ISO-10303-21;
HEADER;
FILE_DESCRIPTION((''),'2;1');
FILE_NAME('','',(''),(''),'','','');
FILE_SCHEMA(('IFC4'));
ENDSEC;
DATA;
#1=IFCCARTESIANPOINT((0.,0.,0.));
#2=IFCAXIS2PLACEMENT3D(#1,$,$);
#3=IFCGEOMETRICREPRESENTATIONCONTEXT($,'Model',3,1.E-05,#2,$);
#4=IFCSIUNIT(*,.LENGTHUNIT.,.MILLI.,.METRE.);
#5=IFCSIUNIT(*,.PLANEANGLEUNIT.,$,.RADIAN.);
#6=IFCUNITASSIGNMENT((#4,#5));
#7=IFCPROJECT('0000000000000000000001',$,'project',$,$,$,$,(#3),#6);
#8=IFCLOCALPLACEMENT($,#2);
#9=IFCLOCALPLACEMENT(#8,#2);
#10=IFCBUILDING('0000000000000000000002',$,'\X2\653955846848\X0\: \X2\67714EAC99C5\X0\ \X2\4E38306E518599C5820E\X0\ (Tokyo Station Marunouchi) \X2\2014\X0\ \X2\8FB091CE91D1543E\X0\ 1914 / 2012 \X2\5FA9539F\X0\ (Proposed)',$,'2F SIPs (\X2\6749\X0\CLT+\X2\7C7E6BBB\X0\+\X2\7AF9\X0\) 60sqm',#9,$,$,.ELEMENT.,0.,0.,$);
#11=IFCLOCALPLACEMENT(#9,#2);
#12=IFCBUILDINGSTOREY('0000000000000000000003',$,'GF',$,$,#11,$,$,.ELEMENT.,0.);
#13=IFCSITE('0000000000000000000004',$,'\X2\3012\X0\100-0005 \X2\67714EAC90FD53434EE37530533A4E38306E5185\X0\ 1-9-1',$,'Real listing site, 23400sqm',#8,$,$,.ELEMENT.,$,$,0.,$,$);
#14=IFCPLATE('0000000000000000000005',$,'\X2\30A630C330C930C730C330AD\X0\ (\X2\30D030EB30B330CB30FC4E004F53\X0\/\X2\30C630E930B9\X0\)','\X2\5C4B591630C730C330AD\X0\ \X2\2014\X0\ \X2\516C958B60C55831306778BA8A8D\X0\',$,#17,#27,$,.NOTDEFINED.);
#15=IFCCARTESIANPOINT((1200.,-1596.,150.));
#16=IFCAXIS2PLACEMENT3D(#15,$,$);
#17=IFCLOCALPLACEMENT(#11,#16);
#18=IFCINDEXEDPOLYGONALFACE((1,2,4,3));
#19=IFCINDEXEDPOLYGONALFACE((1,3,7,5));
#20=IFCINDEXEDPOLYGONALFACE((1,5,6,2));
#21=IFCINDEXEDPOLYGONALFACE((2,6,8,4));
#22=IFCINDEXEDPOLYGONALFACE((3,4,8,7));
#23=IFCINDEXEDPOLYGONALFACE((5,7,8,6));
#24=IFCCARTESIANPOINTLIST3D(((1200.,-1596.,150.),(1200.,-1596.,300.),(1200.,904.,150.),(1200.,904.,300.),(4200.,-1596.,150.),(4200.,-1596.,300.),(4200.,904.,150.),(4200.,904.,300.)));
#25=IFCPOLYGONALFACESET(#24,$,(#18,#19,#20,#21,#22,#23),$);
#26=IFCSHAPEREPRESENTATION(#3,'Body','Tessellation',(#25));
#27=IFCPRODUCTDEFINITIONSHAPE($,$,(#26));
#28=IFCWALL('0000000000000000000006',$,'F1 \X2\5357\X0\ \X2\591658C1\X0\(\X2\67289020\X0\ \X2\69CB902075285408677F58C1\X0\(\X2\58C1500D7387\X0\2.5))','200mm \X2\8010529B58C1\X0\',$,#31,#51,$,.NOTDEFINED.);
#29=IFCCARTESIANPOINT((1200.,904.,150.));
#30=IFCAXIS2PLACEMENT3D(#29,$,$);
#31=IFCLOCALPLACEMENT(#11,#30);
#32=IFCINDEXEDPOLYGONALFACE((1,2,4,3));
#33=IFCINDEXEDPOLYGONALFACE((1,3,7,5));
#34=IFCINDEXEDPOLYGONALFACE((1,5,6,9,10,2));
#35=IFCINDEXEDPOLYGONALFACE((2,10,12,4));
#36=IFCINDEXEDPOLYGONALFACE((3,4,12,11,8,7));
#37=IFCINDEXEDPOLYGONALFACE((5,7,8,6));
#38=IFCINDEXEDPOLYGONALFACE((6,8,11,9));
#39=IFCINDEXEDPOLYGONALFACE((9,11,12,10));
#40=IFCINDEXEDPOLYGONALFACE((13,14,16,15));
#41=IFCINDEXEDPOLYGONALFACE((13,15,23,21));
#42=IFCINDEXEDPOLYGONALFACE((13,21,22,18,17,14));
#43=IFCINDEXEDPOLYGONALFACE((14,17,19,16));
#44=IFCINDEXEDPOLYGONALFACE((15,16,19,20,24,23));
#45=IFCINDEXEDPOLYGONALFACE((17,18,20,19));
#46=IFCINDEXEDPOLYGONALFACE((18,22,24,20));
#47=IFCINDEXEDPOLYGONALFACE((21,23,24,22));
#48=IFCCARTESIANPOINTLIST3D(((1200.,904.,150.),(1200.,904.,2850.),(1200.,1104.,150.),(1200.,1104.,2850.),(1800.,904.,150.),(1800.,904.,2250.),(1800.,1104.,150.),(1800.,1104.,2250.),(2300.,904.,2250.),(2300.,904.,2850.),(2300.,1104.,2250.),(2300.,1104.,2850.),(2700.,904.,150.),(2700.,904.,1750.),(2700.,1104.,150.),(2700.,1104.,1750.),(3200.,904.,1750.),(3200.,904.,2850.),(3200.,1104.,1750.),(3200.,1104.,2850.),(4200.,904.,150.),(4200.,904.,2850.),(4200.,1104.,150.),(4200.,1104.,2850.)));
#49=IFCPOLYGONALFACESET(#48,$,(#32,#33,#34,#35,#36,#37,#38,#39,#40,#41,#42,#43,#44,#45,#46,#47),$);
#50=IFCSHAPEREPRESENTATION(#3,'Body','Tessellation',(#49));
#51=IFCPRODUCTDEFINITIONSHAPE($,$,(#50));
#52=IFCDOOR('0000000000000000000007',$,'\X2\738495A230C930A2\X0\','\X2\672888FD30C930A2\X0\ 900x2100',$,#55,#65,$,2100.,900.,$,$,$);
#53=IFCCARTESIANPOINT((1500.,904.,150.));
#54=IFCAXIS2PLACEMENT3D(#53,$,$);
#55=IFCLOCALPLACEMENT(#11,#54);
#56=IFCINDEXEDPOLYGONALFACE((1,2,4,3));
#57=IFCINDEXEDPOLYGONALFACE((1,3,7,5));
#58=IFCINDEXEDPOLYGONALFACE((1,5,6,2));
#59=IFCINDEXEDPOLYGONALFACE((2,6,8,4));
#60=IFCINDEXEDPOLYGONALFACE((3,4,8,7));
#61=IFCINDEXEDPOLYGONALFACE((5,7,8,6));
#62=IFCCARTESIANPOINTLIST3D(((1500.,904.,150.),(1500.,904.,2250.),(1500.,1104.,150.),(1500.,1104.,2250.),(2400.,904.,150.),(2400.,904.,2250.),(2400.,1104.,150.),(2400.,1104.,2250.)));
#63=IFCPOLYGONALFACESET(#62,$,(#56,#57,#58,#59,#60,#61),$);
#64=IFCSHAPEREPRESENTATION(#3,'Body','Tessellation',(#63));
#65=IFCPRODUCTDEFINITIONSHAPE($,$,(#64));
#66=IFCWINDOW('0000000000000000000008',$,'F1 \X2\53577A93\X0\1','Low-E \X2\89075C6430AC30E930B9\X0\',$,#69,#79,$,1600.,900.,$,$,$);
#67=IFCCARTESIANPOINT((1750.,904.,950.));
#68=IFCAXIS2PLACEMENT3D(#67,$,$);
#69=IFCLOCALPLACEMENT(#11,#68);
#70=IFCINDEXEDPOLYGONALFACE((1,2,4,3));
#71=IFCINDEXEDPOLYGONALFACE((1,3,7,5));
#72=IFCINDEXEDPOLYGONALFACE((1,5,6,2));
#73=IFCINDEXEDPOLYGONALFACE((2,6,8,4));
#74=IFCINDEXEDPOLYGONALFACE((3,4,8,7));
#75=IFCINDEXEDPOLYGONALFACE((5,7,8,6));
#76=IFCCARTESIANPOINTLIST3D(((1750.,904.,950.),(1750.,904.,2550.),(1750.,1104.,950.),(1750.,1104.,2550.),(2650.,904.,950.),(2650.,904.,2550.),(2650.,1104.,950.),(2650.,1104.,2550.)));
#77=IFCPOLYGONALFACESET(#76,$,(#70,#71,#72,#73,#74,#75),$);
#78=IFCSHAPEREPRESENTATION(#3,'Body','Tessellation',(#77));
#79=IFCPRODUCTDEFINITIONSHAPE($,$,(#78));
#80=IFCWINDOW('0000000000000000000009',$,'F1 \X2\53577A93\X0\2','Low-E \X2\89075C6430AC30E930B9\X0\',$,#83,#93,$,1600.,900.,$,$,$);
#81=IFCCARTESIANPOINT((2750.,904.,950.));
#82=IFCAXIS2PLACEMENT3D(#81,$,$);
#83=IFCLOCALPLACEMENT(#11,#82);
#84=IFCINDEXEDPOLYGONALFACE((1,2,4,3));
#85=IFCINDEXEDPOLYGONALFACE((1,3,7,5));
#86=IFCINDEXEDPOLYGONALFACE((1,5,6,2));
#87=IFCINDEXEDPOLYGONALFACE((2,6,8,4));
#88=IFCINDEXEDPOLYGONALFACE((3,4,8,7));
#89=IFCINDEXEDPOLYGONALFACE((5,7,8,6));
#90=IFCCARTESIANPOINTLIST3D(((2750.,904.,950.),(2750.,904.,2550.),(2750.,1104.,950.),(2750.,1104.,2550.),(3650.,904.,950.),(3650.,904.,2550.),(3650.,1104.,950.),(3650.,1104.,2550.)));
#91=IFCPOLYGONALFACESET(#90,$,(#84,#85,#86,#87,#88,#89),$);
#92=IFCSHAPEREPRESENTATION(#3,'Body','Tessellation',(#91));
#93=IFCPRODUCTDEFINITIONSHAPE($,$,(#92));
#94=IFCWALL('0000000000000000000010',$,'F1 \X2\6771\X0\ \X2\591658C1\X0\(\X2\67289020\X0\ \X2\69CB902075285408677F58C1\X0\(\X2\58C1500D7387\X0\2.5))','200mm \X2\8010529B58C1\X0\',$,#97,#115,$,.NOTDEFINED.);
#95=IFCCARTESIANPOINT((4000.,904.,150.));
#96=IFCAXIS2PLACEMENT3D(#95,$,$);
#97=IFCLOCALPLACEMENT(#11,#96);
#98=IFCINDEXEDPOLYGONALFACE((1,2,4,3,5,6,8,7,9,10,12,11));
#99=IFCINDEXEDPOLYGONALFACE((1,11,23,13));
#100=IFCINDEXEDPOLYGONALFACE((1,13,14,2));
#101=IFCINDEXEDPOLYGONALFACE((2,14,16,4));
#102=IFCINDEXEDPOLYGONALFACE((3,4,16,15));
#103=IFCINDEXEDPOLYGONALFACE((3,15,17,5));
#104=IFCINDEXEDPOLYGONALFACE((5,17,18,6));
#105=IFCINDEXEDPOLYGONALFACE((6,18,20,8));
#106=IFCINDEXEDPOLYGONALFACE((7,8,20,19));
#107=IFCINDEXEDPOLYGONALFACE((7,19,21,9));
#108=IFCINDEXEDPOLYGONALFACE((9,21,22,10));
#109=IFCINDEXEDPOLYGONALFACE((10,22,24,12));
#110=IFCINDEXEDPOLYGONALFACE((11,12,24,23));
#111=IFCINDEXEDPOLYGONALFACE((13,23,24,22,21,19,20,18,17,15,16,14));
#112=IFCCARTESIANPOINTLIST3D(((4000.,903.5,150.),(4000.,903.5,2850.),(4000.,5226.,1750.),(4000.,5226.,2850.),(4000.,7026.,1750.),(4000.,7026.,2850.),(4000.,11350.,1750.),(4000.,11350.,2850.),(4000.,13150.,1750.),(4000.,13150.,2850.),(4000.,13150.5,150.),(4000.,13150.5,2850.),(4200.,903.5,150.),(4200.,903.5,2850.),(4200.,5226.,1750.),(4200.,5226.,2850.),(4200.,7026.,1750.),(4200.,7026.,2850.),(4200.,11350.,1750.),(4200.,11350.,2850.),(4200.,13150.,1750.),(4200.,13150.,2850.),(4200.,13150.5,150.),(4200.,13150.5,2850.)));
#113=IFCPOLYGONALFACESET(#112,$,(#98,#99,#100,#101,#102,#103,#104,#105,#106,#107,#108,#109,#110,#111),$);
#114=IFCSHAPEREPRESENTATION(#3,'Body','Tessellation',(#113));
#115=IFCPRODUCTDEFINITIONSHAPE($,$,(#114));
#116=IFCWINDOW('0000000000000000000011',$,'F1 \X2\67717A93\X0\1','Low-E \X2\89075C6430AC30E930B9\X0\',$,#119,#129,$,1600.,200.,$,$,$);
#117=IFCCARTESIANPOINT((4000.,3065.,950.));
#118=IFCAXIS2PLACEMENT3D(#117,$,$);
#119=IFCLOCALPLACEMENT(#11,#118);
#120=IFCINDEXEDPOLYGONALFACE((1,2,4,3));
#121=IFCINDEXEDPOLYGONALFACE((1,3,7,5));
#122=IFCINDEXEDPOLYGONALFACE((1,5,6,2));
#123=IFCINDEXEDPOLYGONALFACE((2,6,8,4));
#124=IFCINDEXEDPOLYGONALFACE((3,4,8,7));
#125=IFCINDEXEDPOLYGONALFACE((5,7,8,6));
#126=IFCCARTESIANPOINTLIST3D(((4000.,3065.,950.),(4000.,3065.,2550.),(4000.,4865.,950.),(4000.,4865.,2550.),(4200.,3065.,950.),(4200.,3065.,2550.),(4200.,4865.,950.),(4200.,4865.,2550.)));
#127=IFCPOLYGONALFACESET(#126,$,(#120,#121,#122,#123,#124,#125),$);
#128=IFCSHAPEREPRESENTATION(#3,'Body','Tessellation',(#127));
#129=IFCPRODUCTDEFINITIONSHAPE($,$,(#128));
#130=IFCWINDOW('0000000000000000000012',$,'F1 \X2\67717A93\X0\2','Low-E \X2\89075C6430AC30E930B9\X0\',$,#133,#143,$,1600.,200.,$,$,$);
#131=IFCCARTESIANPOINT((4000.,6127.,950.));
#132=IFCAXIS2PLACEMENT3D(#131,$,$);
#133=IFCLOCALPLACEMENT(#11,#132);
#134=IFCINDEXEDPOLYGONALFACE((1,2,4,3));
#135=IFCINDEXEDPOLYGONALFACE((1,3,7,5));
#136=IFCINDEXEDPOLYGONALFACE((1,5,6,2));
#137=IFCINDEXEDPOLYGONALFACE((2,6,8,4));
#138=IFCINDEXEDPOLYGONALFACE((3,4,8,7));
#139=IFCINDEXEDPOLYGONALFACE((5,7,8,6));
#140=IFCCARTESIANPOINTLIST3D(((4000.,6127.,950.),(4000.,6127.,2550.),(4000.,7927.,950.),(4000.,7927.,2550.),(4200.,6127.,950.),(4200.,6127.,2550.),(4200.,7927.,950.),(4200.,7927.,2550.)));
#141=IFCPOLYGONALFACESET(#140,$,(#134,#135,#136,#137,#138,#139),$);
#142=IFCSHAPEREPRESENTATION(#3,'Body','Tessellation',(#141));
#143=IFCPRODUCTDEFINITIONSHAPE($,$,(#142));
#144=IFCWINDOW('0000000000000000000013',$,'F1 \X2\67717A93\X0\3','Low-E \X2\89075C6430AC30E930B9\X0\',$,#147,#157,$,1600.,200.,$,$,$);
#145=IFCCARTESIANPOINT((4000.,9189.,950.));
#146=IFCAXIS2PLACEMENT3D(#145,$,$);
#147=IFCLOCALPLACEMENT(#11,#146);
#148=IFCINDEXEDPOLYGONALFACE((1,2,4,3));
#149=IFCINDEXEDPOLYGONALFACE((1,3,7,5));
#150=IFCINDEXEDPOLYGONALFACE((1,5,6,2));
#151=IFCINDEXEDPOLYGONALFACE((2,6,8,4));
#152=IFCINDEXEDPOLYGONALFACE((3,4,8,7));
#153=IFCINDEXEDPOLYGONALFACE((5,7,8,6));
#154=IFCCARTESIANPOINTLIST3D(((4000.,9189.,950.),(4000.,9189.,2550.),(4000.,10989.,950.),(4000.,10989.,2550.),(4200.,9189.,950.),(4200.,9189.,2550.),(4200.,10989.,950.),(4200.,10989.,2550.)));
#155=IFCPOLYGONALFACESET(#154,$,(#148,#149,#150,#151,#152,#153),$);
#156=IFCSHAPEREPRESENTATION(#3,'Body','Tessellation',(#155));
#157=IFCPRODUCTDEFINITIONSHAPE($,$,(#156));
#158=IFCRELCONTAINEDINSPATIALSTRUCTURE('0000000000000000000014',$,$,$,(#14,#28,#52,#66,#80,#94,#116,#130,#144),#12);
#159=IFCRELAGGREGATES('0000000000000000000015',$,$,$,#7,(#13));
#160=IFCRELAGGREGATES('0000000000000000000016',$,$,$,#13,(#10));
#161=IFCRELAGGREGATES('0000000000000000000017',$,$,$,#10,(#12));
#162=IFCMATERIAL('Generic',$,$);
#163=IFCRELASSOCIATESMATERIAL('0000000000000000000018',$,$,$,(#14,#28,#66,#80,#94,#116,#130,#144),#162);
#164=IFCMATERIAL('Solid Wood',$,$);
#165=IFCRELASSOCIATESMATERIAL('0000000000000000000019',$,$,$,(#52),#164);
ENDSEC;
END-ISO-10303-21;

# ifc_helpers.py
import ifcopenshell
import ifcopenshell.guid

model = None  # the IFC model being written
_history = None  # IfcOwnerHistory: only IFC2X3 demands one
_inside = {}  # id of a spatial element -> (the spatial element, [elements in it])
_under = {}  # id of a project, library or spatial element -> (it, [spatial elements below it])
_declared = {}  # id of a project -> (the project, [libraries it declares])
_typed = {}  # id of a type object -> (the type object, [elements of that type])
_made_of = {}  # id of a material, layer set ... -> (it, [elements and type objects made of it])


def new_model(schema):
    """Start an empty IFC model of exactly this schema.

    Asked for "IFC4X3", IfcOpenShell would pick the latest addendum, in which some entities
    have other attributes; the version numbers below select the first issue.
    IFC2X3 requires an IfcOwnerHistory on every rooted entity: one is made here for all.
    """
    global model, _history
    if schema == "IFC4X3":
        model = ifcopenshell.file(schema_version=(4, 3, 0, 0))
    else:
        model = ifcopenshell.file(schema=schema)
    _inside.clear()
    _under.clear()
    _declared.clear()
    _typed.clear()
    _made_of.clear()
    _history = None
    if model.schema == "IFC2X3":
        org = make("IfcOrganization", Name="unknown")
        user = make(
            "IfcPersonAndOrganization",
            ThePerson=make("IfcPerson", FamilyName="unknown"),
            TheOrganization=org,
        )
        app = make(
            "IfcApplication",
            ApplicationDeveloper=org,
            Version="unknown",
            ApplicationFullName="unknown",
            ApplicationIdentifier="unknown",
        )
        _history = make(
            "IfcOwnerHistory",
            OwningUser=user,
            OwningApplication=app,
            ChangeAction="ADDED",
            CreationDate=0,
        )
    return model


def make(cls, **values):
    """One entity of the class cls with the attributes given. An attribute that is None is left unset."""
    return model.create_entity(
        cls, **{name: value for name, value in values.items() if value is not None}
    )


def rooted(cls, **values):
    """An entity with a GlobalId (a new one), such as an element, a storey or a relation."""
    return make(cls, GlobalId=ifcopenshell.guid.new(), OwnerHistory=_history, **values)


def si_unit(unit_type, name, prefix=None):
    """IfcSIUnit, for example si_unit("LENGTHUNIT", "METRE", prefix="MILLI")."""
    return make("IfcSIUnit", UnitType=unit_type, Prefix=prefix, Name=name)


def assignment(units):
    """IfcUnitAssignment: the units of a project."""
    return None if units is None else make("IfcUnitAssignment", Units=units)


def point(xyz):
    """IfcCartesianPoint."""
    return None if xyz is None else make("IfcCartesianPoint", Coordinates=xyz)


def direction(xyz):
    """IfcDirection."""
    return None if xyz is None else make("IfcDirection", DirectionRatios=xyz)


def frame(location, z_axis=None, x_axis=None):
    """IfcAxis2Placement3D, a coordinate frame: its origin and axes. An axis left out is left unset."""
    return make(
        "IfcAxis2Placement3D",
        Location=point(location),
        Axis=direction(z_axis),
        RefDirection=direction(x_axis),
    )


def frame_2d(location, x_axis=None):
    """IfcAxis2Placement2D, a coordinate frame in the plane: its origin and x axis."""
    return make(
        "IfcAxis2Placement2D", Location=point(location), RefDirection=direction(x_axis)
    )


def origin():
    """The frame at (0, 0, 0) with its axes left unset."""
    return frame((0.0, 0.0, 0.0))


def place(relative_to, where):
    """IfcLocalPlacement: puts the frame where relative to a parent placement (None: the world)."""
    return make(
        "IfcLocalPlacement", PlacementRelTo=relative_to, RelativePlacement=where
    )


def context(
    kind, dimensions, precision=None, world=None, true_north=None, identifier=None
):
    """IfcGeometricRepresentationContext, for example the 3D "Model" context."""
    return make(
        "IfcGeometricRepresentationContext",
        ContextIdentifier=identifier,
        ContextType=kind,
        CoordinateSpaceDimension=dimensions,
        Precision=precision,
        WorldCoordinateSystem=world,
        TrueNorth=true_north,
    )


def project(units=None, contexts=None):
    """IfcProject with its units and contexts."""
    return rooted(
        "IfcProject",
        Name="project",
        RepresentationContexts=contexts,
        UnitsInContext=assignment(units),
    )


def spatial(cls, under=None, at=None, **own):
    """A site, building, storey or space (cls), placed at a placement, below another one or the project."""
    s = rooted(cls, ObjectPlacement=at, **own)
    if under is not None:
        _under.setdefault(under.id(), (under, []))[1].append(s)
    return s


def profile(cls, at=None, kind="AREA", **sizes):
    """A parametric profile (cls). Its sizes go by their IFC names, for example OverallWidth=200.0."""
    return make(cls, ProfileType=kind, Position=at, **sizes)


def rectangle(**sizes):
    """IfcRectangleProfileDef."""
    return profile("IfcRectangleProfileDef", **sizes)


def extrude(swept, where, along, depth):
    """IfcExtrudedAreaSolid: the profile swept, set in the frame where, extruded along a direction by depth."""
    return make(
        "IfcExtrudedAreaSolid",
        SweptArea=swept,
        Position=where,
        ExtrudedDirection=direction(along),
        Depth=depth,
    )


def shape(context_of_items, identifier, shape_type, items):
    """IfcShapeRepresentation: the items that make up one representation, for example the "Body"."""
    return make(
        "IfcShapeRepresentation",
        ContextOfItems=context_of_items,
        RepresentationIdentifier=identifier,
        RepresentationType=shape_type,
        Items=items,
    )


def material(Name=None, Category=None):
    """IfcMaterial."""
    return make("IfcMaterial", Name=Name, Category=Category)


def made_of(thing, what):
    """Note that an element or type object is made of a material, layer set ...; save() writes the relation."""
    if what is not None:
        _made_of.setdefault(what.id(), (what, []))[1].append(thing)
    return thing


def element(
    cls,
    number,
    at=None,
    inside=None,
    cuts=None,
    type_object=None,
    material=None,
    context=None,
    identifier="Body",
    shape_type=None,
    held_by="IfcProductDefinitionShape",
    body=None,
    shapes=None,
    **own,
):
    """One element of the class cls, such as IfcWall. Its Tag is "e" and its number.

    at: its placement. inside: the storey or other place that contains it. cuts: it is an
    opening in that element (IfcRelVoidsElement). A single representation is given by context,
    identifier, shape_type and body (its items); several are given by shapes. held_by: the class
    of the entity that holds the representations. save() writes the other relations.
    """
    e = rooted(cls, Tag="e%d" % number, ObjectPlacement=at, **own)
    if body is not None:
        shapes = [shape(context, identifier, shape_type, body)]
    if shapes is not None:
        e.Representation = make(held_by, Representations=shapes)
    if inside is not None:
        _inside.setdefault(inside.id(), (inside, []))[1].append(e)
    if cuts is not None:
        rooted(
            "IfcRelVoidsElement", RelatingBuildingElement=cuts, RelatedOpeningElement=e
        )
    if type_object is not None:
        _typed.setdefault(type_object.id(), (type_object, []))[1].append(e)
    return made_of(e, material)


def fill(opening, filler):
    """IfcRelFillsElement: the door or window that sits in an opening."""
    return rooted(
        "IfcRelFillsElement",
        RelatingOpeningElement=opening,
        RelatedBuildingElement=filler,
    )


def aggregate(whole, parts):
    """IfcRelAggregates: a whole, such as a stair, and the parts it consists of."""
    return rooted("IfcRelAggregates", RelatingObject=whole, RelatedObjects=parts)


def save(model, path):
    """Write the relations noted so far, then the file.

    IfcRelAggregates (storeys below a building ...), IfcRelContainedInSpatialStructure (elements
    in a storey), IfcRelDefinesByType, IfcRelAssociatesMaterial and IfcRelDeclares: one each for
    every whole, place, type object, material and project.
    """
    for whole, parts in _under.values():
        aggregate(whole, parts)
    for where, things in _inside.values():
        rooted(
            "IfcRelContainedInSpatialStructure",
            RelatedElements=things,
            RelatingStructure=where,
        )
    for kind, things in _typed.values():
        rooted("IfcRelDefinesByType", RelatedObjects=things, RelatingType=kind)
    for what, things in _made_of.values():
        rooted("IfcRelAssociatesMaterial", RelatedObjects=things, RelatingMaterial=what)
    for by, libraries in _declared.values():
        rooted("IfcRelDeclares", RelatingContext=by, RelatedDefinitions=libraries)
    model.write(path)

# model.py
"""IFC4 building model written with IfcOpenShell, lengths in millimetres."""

from ifc_helpers import new_model, si_unit, frame, frame_2d, origin, place, context, project, spatial, rectangle, extrude, material, element, fill, save


model = new_model("IFC4")

# Units and contexts
model_context = context("Model", 3, precision=1e-05, world=origin())
ifc_project = project(units=[si_unit("LENGTHUNIT", "METRE", prefix="MILLI"), si_unit("PLANEANGLEUNIT", "RADIAN")], contexts=[model_context])

# Site, building, storey
site_placement = place(None, origin())
site = spatial("IfcSite", under=ifc_project, at=site_placement, Name="〒100-0005 東京都千代田区丸の内 1-9-1", ObjectType="Real listing site, 23400sqm", CompositionType="ELEMENT", RefElevation=0.0)
building_placement = place(site_placement, origin())
building = spatial("IfcBuilding", under=site, at=building_placement, Name="改善案: 東京駅 丸の内駅舎 (Tokyo Station Marunouchi) — 辰野金吾 1914 / 2012 復原 (Proposed)", ObjectType="2F SIPs (杉CLT+籾殻+竹) 60sqm", CompositionType="ELEMENT", ElevationOfRefHeight=0.0, ElevationOfTerrain=0.0)
storey_placement = place(building_placement, origin())
storey = spatial("IfcBuildingStorey", under=building, at=storey_placement, Name="GF", CompositionType="ELEMENT", Elevation=0.0)

# Shared definitions
ifc_material_1 = material(Name="Generic")

# Plate
plate_placement = place(storey_placement, frame((1200.0, -1596.0, 150.0)))
element("IfcPlate", 1, at=plate_placement, inside=storey, material=ifc_material_1, Name="ウッドデッキ (バルコニー一体/テラス)", Description="屋外デッキ — 公開情報で確認", PredefinedType="NOTDEFINED", context=model_context, shape_type="SweptSolid", body=[
    extrude(rectangle(XDim=3000.0, YDim=2500.0, at=frame_2d((1500.0, 1250.0))), frame((1200.0, -1596.0, 150.0)), (0.0, 0.0, 1.0), 150.0),
])

# Wall, openings, door, windows
wall_1_placement = place(storey_placement, frame((1200.0, 904.0, 150.0)))
wall_1 = element("IfcWall", 2, at=wall_1_placement, inside=storey, material=ifc_material_1, Name="F1 南 外壁(木造 構造用合板壁(壁倍率2.5))", Description="200mm 耐力壁", PredefinedType="NOTDEFINED", context=model_context, shape_type="SweptSolid", body=[
    extrude(rectangle(XDim=3000.0, YDim=200.0, at=frame_2d((1500.0, 100.0))), frame((1200.0, 904.0, 150.0)), (0.0, 0.0, 1.0), 2700.0),
])
opening_1_placement = place(storey_placement, frame((1500.0, 904.0, 150.0)))
opening_1 = element("IfcOpeningElement", 3, at=opening_1_placement, cuts=wall_1, PredefinedType="NOTDEFINED", context=model_context, shape_type="SweptSolid", body=[
    extrude(rectangle(XDim=900.0, YDim=200.0, at=frame_2d((450.0, 100.0))), frame((1500.0, 904.0, 150.0)), (0.0, 0.0, 1.0), 2100.0),
])
opening_2_placement = place(storey_placement, frame((1750.0, 904.0, 950.0)))
opening_2 = element("IfcOpeningElement", 4, at=opening_2_placement, cuts=wall_1, PredefinedType="NOTDEFINED", context=model_context, shape_type="SweptSolid", body=[
    extrude(rectangle(XDim=900.0, YDim=200.0, at=frame_2d((450.0, 100.0))), frame((1750.0, 904.0, 950.0)), (0.0, 0.0, 1.0), 1600.0),
])
opening_3_placement = place(storey_placement, frame((2750.0, 904.0, 950.0)))
opening_3 = element("IfcOpeningElement", 5, at=opening_3_placement, cuts=wall_1, PredefinedType="NOTDEFINED", context=model_context, shape_type="SweptSolid", body=[
    extrude(rectangle(XDim=900.0, YDim=200.0, at=frame_2d((450.0, 100.0))), frame((2750.0, 904.0, 950.0)), (0.0, 0.0, 1.0), 1600.0),
])
ifc_material_2 = material(Name="Solid Wood")
door_placement = place(storey_placement, frame((1500.0, 904.0, 150.0)))
door = element("IfcDoor", 6, at=door_placement, inside=storey, material=ifc_material_2, Name="玄関ドア", Description="木製ドア 900x2100", OverallHeight=2100.0, OverallWidth=900.0, context=model_context, shape_type="SweptSolid", body=[
    extrude(rectangle(XDim=900.0, YDim=200.0, at=frame_2d((450.0, 100.0))), frame((1500.0, 904.0, 150.0)), (0.0, 0.0, 1.0), 2100.0),
])
fill(opening_1, door)
window_1_placement = place(storey_placement, frame((1750.0, 904.0, 950.0)))
window_1 = element("IfcWindow", 7, at=window_1_placement, inside=storey, material=ifc_material_1, Name="F1 南窓1", Description="Low-E 複層ガラス", OverallHeight=1600.0, OverallWidth=900.0, context=model_context, shape_type="SweptSolid", body=[
    extrude(rectangle(XDim=900.0, YDim=200.0, at=frame_2d((450.0, 100.0))), frame((1750.0, 904.0, 950.0)), (0.0, 0.0, 1.0), 1600.0),
])
fill(opening_2, window_1)
window_2_placement = place(storey_placement, frame((2750.0, 904.0, 950.0)))
window_2 = element("IfcWindow", 8, at=window_2_placement, inside=storey, material=ifc_material_1, Name="F1 南窓2", Description="Low-E 複層ガラス", OverallHeight=1600.0, OverallWidth=900.0, context=model_context, shape_type="SweptSolid", body=[
    extrude(rectangle(XDim=900.0, YDim=200.0, at=frame_2d((450.0, 100.0))), frame((2750.0, 904.0, 950.0)), (0.0, 0.0, 1.0), 1600.0),
])
fill(opening_3, window_2)

# Wall, openings, windows
wall_2_placement = place(storey_placement, frame((4000.0, 904.0, 150.0)))
wall_2 = element("IfcWall", 9, at=wall_2_placement, inside=storey, material=ifc_material_1, Name="F1 東 外壁(木造 構造用合板壁(壁倍率2.5))", Description="200mm 耐力壁", PredefinedType="NOTDEFINED", context=model_context, shape_type="SweptSolid", body=[
    extrude(rectangle(XDim=200.0, YDim=12247.0, at=frame_2d((100.0, 6123.0))), frame((4000.0, 904.0, 150.0)), (0.0, 0.0, 1.0), 2700.0),
])
opening_4_placement = place(storey_placement, frame((4000.0, 3065.0, 950.0)))
opening_4 = element("IfcOpeningElement", 10, at=opening_4_placement, cuts=wall_2, PredefinedType="NOTDEFINED", context=model_context, shape_type="SweptSolid", body=[
    extrude(rectangle(XDim=200.0, YDim=1800.0, at=frame_2d((100.0, 900.0))), frame((4000.0, 3065.0, 950.0)), (0.0, 0.0, 1.0), 1600.0),
])
opening_5_placement = place(storey_placement, frame((4000.0, 6127.0, 950.0)))
opening_5 = element("IfcOpeningElement", 11, at=opening_5_placement, cuts=wall_2, PredefinedType="NOTDEFINED", context=model_context, shape_type="SweptSolid", body=[
    extrude(rectangle(XDim=200.0, YDim=1800.0, at=frame_2d((100.0, 900.0))), frame((4000.0, 6127.0, 950.0)), (0.0, 0.0, 1.0), 1600.0),
])
opening_6_placement = place(storey_placement, frame((4000.0, 9189.0, 950.0)))
opening_6 = element("IfcOpeningElement", 12, at=opening_6_placement, cuts=wall_2, PredefinedType="NOTDEFINED", context=model_context, shape_type="SweptSolid", body=[
    extrude(rectangle(XDim=200.0, YDim=1800.0, at=frame_2d((100.0, 900.0))), frame((4000.0, 9189.0, 950.0)), (0.0, 0.0, 1.0), 1600.0),
])
window_3_placement = place(storey_placement, frame((4000.0, 3065.0, 950.0)))
window_3 = element("IfcWindow", 13, at=window_3_placement, inside=storey, material=ifc_material_1, Name="F1 東窓1", Description="Low-E 複層ガラス", OverallHeight=1600.0, OverallWidth=200.0, context=model_context, shape_type="SweptSolid", body=[
    extrude(rectangle(XDim=200.0, YDim=1800.0, at=frame_2d((100.0, 900.0))), frame((4000.0, 3065.0, 950.0)), (0.0, 0.0, 1.0), 1600.0),
])
fill(opening_4, window_3)
window_4_placement = place(storey_placement, frame((4000.0, 6127.0, 950.0)))
window_4 = element("IfcWindow", 14, at=window_4_placement, inside=storey, material=ifc_material_1, Name="F1 東窓2", Description="Low-E 複層ガラス", OverallHeight=1600.0, OverallWidth=200.0, context=model_context, shape_type="SweptSolid", body=[
    extrude(rectangle(XDim=200.0, YDim=1800.0, at=frame_2d((100.0, 900.0))), frame((4000.0, 6127.0, 950.0)), (0.0, 0.0, 1.0), 1600.0),
])
fill(opening_5, window_4)
window_5_placement = place(storey_placement, frame((4000.0, 9189.0, 950.0)))
window_5 = element("IfcWindow", 15, at=window_5_placement, inside=storey, material=ifc_material_1, Name="F1 東窓3", Description="Low-E 複層ガラス", OverallHeight=1600.0, OverallWidth=200.0, context=model_context, shape_type="SweptSolid", body=[
    extrude(rectangle(XDim=200.0, YDim=1800.0, at=frame_2d((100.0, 900.0))), frame((4000.0, 9189.0, 950.0)), (0.0, 0.0, 1.0), 1600.0),
])
fill(opening_6, window_5)

save(model, "model.ifc")
